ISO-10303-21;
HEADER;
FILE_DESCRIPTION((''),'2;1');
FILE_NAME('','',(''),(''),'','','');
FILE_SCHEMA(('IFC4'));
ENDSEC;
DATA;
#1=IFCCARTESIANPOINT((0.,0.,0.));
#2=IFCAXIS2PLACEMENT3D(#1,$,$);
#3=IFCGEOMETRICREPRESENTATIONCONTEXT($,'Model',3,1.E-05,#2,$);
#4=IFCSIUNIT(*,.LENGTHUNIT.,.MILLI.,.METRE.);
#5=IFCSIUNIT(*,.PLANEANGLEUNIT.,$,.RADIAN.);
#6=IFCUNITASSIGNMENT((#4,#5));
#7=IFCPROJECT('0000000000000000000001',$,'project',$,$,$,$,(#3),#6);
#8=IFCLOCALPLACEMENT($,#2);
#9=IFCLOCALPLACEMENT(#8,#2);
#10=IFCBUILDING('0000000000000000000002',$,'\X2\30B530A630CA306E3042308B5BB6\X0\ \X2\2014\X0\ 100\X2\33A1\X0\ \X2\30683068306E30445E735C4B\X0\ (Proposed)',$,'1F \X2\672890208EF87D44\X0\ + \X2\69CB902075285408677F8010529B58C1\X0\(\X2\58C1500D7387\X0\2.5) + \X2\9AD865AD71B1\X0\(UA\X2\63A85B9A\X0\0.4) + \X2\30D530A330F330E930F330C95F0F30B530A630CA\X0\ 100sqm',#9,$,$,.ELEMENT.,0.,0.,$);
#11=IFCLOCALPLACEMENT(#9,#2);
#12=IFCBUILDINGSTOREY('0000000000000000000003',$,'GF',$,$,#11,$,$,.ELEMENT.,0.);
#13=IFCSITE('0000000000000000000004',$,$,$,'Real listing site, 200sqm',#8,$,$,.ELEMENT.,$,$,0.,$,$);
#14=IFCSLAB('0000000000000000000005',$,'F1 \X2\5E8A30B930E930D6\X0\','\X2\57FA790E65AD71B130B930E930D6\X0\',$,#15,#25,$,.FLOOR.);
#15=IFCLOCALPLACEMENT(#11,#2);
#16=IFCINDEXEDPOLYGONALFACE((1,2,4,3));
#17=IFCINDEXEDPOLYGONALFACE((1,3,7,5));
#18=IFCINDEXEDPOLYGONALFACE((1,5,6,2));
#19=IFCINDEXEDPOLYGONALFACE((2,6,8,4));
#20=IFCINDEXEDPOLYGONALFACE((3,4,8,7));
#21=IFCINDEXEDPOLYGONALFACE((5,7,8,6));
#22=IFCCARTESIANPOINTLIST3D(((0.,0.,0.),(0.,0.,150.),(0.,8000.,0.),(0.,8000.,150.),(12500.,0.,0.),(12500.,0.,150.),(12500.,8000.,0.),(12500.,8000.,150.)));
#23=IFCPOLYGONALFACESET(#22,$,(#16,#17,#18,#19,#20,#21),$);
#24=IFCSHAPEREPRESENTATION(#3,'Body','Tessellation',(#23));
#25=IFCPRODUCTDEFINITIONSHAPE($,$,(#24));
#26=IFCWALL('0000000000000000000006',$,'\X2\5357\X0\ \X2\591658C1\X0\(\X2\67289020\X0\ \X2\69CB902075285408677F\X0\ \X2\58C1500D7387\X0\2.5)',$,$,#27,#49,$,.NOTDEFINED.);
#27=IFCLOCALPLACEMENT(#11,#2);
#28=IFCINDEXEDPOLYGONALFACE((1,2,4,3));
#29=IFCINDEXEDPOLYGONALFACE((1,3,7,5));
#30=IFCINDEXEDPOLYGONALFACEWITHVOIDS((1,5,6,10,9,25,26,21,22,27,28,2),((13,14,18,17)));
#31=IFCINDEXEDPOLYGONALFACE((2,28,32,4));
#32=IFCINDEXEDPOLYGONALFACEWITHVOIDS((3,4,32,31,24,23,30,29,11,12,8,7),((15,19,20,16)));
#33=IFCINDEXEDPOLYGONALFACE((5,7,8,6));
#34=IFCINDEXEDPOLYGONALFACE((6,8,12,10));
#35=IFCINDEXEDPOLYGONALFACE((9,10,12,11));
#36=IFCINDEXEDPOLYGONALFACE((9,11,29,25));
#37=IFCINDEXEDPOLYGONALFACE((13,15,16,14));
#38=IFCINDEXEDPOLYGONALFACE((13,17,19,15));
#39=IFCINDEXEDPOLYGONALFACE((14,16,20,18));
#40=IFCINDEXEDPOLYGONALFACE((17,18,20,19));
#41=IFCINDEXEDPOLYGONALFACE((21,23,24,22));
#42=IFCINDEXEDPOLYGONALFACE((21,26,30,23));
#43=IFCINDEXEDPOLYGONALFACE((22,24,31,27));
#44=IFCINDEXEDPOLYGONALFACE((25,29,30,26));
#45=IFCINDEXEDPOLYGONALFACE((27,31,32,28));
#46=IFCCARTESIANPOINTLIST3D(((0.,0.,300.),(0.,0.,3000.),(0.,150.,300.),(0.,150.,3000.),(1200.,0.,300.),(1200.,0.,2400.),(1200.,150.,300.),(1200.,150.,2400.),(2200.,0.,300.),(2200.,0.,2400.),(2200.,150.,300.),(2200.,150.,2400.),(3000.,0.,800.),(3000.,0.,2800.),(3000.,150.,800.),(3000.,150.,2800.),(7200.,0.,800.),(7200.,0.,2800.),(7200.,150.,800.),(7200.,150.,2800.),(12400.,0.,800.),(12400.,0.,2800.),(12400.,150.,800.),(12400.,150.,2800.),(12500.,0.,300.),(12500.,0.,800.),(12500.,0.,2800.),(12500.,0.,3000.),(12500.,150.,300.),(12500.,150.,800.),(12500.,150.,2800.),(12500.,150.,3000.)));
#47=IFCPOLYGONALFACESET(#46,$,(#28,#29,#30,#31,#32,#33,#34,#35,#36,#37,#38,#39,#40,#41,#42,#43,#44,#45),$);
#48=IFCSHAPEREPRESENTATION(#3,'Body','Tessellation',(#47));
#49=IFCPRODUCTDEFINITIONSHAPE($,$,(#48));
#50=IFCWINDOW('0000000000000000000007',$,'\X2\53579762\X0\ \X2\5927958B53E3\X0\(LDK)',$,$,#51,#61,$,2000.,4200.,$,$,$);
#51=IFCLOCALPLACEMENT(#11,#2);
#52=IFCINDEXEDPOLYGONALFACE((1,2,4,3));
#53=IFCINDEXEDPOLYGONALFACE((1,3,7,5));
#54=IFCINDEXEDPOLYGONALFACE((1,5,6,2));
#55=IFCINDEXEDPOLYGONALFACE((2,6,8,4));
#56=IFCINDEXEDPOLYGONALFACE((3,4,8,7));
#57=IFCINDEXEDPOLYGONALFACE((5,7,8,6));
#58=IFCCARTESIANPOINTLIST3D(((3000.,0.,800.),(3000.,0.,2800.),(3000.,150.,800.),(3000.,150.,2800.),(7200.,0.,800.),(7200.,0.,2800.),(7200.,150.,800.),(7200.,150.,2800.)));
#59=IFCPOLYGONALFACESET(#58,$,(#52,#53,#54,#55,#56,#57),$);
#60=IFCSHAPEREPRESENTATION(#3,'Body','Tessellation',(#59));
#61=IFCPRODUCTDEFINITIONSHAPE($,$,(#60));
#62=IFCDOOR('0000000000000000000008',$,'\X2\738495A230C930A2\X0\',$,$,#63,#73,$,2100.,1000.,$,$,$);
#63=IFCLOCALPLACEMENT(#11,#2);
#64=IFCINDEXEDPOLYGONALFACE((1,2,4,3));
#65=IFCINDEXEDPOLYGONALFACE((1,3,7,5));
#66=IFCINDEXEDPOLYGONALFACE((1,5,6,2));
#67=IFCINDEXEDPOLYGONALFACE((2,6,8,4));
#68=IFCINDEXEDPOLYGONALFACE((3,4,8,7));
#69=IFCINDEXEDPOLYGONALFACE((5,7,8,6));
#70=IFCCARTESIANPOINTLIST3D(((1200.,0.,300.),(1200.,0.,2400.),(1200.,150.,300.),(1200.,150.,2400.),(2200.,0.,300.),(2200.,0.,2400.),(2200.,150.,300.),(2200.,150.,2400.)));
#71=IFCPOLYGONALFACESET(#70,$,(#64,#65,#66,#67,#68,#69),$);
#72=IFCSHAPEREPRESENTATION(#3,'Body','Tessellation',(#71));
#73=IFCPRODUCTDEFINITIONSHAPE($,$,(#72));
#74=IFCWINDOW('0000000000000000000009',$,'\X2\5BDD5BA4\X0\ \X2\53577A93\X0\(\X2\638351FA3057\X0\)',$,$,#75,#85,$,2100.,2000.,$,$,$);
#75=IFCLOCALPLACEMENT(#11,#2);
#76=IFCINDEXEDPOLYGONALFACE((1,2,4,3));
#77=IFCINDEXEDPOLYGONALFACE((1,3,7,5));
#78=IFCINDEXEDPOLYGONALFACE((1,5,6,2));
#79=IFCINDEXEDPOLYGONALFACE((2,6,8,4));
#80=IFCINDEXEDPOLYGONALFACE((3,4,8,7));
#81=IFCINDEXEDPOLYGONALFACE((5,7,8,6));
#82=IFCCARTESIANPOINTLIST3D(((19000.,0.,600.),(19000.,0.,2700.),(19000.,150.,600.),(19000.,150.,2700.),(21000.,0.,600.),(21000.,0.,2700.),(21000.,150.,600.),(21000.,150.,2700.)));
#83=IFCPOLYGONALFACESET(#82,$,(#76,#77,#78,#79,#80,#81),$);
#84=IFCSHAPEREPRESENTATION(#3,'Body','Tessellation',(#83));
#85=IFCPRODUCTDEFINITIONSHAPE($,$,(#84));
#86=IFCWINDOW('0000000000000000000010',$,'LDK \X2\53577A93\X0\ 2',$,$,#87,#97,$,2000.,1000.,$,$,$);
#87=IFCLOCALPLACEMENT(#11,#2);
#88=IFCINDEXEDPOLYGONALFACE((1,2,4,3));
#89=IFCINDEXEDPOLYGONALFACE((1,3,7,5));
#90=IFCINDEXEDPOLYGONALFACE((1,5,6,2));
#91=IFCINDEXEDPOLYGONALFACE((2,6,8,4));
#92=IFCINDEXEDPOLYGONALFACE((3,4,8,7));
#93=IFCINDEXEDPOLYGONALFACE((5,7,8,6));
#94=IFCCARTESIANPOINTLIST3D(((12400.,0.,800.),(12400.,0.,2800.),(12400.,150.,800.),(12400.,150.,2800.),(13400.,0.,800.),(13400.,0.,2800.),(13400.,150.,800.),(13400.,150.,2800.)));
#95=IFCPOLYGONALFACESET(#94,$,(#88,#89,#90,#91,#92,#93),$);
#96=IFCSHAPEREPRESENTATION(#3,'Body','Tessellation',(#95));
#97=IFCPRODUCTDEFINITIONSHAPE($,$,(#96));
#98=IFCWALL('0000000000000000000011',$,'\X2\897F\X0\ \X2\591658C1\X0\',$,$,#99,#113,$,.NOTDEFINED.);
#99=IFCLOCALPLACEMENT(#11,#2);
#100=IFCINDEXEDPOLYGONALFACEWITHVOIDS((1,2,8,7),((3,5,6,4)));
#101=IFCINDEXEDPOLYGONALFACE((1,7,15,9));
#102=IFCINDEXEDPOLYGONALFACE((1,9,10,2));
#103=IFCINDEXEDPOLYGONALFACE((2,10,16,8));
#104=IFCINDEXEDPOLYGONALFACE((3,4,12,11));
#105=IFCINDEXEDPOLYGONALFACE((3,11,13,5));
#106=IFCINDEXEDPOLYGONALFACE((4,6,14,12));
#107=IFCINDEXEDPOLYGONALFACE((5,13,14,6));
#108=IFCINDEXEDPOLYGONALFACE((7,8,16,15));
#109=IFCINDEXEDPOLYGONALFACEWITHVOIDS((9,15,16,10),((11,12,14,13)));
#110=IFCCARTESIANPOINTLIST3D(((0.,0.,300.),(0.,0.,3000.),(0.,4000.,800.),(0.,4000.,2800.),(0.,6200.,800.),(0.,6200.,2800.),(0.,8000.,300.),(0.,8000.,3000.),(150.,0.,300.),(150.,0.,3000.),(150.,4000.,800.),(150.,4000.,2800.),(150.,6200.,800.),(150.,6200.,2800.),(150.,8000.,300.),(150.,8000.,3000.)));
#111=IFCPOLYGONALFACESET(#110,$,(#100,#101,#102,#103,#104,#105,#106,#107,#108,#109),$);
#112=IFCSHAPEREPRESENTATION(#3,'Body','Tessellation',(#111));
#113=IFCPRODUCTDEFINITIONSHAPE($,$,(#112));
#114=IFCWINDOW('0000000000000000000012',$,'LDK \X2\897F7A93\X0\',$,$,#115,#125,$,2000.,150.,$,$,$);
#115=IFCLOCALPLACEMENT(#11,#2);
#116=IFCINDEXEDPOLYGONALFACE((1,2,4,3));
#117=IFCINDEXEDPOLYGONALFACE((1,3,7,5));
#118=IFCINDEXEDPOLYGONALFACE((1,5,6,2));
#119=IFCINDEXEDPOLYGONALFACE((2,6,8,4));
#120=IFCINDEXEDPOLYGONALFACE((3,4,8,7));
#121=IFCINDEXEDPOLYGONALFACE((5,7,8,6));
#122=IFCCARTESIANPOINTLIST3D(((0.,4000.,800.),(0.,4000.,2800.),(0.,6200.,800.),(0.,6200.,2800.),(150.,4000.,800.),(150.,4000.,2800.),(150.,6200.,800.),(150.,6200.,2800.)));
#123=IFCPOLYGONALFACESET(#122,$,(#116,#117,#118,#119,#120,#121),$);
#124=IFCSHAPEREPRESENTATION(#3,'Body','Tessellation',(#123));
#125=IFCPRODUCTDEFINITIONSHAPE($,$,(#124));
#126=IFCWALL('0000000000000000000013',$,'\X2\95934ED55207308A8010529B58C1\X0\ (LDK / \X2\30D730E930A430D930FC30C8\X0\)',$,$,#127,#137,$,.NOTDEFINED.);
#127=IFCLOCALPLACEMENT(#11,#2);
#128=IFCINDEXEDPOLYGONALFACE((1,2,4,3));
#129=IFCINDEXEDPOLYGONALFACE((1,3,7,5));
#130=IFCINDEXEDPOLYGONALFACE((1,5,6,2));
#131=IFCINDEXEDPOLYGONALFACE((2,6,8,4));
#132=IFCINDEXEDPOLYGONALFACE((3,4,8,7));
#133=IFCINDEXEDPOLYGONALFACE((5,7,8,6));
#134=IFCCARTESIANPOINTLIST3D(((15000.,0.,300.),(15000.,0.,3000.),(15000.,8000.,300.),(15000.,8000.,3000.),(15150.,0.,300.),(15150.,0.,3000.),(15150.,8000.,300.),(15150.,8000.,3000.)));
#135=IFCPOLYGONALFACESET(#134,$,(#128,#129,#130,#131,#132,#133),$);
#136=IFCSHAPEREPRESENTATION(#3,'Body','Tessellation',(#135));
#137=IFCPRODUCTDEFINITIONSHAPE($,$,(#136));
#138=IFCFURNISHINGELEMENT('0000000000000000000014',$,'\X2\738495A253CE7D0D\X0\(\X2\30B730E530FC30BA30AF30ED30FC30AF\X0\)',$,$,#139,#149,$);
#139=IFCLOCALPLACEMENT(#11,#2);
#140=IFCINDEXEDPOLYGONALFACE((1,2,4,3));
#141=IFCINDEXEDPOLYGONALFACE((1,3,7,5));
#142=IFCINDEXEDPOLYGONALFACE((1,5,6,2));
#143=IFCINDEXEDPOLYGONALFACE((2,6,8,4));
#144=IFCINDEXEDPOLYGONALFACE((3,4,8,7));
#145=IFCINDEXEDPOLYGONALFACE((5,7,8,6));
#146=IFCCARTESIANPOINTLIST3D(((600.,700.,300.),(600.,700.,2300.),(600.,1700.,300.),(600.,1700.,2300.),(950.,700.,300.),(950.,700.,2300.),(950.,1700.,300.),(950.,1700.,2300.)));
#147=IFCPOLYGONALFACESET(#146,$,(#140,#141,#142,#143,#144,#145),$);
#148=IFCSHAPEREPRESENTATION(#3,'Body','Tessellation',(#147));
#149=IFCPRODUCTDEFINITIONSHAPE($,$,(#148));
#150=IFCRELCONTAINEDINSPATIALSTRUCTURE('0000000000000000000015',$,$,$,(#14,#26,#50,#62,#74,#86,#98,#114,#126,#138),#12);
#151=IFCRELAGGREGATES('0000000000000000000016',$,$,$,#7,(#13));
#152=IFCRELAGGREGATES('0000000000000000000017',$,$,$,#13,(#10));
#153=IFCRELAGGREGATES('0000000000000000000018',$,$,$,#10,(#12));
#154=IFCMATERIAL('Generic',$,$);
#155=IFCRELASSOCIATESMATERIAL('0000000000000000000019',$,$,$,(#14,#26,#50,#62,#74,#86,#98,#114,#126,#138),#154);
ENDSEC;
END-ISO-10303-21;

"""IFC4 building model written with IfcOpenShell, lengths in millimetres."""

from ifc_helpers import new_model, si_unit, frame, frame_2d, origin, place, context, project, spatial, rectangle, extrude, material, element, fill, save


model = new_model("IFC4")

# Units and contexts
model_context = context("Model", 3, precision=1e-05, world=origin())
ifc_project = project(units=[si_unit("LENGTHUNIT", "METRE", prefix="MILLI"), si_unit("PLANEANGLEUNIT", "RADIAN")], contexts=[model_context])

# Site, building, storey
site_placement = place(None, origin())
site = spatial("IfcSite", under=ifc_project, at=site_placement, ObjectType="Real listing site, 200sqm", CompositionType="ELEMENT", RefElevation=0.0)
building_placement = place(site_placement, origin())
building = spatial("IfcBuilding", under=site, at=building_placement, Name="サウナのある家 — 100㎡ ととのい平屋 (Proposed)", ObjectType="1F 木造軸組 + 構造用合板耐力壁(壁倍率2.5) + 高断熱(UA推定0.4) + フィンランド式サウナ 100sqm", CompositionType="ELEMENT", ElevationOfRefHeight=0.0, ElevationOfTerrain=0.0)
storey_placement = place(building_placement, origin())
storey = spatial("IfcBuildingStorey", under=building, at=storey_placement, Name="GF", CompositionType="ELEMENT", Elevation=0.0)

# Slab
ifc_material = material(Name="Generic")
slab_placement = place(storey_placement, origin())
element("IfcSlab", 1, at=slab_placement, inside=storey, material=ifc_material, Name="F1 床スラブ", Description="基礎断熱スラブ", PredefinedType="FLOOR", context=model_context, shape_type="SweptSolid", body=[
    extrude(rectangle(XDim=12500.0, YDim=8000.0, at=frame_2d((6250.0, 4000.0))), origin(), (0.0, 0.0, 1.0), 150.0),
])

# Wall, openings, windows, door
wall_1_placement = place(storey_placement, frame((0.0, 0.0, 150.0)))
wall_1 = element("IfcWall", 2, at=wall_1_placement, inside=storey, material=ifc_material, Name="南 外壁(木造 構造用合板 壁倍率2.5)", PredefinedType="NOTDEFINED", context=model_context, shape_type="SweptSolid", body=[
    extrude(rectangle(XDim=12500.0, YDim=150.0, at=frame_2d((6250.0, 75.0))), frame((0.0, 0.0, 150.0)), (0.0, 0.0, 1.0), 2700.0),
])
opening_1_placement = place(storey_placement, frame((1500.0, 0.0, 400.0)))
opening_1 = element("IfcOpeningElement", 3, at=opening_1_placement, cuts=wall_1, PredefinedType="NOTDEFINED", context=model_context, shape_type="SweptSolid", body=[
    extrude(rectangle(XDim=4200.0, YDim=150.0, at=frame_2d((2100.0, 75.0))), frame((1500.0, 0.0, 400.0)), (0.0, 0.0, 1.0), 2000.0),
])
opening_2_placement = place(storey_placement, frame((600.0, 0.0, 150.0)))
opening_2 = element("IfcOpeningElement", 4, at=opening_2_placement, cuts=wall_1, PredefinedType="NOTDEFINED", context=model_context, shape_type="SweptSolid", body=[
    extrude(rectangle(XDim=1000.0, YDim=150.0, at=frame_2d((500.0, 75.0))), frame((600.0, 0.0, 150.0)), (0.0, 0.0, 1.0), 2100.0),
])
opening_3_placement = place(storey_placement, frame((9500.0, 0.0, 300.0)))
opening_3 = element("IfcOpeningElement", 5, at=opening_3_placement, cuts=wall_1, PredefinedType="NOTDEFINED", context=model_context, shape_type="SweptSolid", body=[
    extrude(rectangle(XDim=2000.0, YDim=150.0, at=frame_2d((1000.0, 75.0))), frame((9500.0, 0.0, 300.0)), (0.0, 0.0, 1.0), 2100.0),
])
opening_4_placement = place(storey_placement, frame((6200.0, 0.0, 400.0)))
opening_4 = element("IfcOpeningElement", 6, at=opening_4_placement, cuts=wall_1, PredefinedType="NOTDEFINED", context=model_context, shape_type="SweptSolid", body=[
    extrude(rectangle(XDim=1000.0, YDim=150.0, at=frame_2d((500.0, 75.0))), frame((6200.0, 0.0, 400.0)), (0.0, 0.0, 1.0), 2000.0),
])
window_1_placement = place(storey_placement, frame((1500.0, 0.0, 400.0)))
window_1 = element("IfcWindow", 7, at=window_1_placement, inside=storey, material=ifc_material, Name="南面 大開口(LDK)", OverallHeight=2000.0, OverallWidth=4200.0, context=model_context, shape_type="SweptSolid", body=[
    extrude(rectangle(XDim=4200.0, YDim=150.0, at=frame_2d((2100.0, 75.0))), frame((1500.0, 0.0, 400.0)), (0.0, 0.0, 1.0), 2000.0),
])
fill(opening_1, window_1)
door_placement = place(storey_placement, frame((600.0, 0.0, 150.0)))
door = element("IfcDoor", 8, at=door_placement, inside=storey, material=ifc_material, Name="玄関ドア", OverallHeight=2100.0, OverallWidth=1000.0, context=model_context, shape_type="SweptSolid", body=[
    extrude(rectangle(XDim=1000.0, YDim=150.0, at=frame_2d((500.0, 75.0))), frame((600.0, 0.0, 150.0)), (0.0, 0.0, 1.0), 2100.0),
])
fill(opening_2, door)
window_2_placement = place(storey_placement, frame((9500.0, 0.0, 300.0)))
window_2 = element("IfcWindow", 9, at=window_2_placement, inside=storey, material=ifc_material, Name="寝室 南窓(掃出し)", OverallHeight=2100.0, OverallWidth=2000.0, context=model_context, shape_type="SweptSolid", body=[
    extrude(rectangle(XDim=2000.0, YDim=150.0, at=frame_2d((1000.0, 75.0))), frame((9500.0, 0.0, 300.0)), (0.0, 0.0, 1.0), 2100.0),
])
fill(opening_3, window_2)
window_3_placement = place(storey_placement, frame((6200.0, 0.0, 400.0)))
window_3 = element("IfcWindow", 10, at=window_3_placement, inside=storey, material=ifc_material, Name="LDK 南窓 2", OverallHeight=2000.0, OverallWidth=1000.0, context=model_context, shape_type="SweptSolid", body=[
    extrude(rectangle(XDim=1000.0, YDim=150.0, at=frame_2d((500.0, 75.0))), frame((6200.0, 0.0, 400.0)), (0.0, 0.0, 1.0), 2000.0),
])
fill(opening_4, window_3)

# Wall, opening, window
wall_2_placement = place(storey_placement, frame((0.0, 0.0, 150.0)))
wall_2 = element("IfcWall", 11, at=wall_2_placement, inside=storey, material=ifc_material, Name="西 外壁", PredefinedType="NOTDEFINED", context=model_context, shape_type="SweptSolid", body=[
    extrude(rectangle(XDim=150.0, YDim=8000.0, at=frame_2d((75.0, 4000.0))), frame((0.0, 0.0, 150.0)), (0.0, 0.0, 1.0), 2700.0),
])
opening_5_placement = place(storey_placement, frame((0.0, 2000.0, 400.0)))
opening_5 = element("IfcOpeningElement", 12, at=opening_5_placement, cuts=wall_2, PredefinedType="NOTDEFINED", context=model_context, shape_type="SweptSolid", body=[
    extrude(rectangle(XDim=150.0, YDim=2200.0, at=frame_2d((75.0, 1100.0))), frame((0.0, 2000.0, 400.0)), (0.0, 0.0, 1.0), 2000.0),
])
window_4_placement = place(storey_placement, frame((0.0, 2000.0, 400.0)))
window_4 = element("IfcWindow", 13, at=window_4_placement, inside=storey, material=ifc_material, Name="LDK 西窓", OverallHeight=2000.0, OverallWidth=150.0, context=model_context, shape_type="SweptSolid", body=[
    extrude(rectangle(XDim=150.0, YDim=2200.0, at=frame_2d((75.0, 1100.0))), frame((0.0, 2000.0, 400.0)), (0.0, 0.0, 1.0), 2000.0),
])
fill(opening_5, window_4)

# Wall
wall_3_placement = place(storey_placement, frame((7500.0, 0.0, 150.0)))
element("IfcWall", 14, at=wall_3_placement, inside=storey, material=ifc_material, Name="間仕切り耐力壁 (LDK / プライベート)", PredefinedType="NOTDEFINED", context=model_context, shape_type="SweptSolid", body=[
    extrude(rectangle(XDim=150.0, YDim=8000.0, at=frame_2d((75.0, 4000.0))), frame((7500.0, 0.0, 150.0)), (0.0, 0.0, 1.0), 2700.0),
])

# Furnishing element
furnishing_1_placement = place(storey_placement, frame((300.0, 350.0, 150.0)))
element("IfcFurnishingElement", 15, at=furnishing_1_placement, inside=storey, material=ifc_material, Name="玄関収納(シューズクローク)", context=model_context, shape_type="SweptSolid", body=[
    extrude(rectangle(XDim=350.0, YDim=1000.0, at=frame_2d((175.0, 500.0))), frame((300.0, 350.0, 150.0)), (0.0, 0.0, 1.0), 2000.0),
])

save(model, "model.ifc")
